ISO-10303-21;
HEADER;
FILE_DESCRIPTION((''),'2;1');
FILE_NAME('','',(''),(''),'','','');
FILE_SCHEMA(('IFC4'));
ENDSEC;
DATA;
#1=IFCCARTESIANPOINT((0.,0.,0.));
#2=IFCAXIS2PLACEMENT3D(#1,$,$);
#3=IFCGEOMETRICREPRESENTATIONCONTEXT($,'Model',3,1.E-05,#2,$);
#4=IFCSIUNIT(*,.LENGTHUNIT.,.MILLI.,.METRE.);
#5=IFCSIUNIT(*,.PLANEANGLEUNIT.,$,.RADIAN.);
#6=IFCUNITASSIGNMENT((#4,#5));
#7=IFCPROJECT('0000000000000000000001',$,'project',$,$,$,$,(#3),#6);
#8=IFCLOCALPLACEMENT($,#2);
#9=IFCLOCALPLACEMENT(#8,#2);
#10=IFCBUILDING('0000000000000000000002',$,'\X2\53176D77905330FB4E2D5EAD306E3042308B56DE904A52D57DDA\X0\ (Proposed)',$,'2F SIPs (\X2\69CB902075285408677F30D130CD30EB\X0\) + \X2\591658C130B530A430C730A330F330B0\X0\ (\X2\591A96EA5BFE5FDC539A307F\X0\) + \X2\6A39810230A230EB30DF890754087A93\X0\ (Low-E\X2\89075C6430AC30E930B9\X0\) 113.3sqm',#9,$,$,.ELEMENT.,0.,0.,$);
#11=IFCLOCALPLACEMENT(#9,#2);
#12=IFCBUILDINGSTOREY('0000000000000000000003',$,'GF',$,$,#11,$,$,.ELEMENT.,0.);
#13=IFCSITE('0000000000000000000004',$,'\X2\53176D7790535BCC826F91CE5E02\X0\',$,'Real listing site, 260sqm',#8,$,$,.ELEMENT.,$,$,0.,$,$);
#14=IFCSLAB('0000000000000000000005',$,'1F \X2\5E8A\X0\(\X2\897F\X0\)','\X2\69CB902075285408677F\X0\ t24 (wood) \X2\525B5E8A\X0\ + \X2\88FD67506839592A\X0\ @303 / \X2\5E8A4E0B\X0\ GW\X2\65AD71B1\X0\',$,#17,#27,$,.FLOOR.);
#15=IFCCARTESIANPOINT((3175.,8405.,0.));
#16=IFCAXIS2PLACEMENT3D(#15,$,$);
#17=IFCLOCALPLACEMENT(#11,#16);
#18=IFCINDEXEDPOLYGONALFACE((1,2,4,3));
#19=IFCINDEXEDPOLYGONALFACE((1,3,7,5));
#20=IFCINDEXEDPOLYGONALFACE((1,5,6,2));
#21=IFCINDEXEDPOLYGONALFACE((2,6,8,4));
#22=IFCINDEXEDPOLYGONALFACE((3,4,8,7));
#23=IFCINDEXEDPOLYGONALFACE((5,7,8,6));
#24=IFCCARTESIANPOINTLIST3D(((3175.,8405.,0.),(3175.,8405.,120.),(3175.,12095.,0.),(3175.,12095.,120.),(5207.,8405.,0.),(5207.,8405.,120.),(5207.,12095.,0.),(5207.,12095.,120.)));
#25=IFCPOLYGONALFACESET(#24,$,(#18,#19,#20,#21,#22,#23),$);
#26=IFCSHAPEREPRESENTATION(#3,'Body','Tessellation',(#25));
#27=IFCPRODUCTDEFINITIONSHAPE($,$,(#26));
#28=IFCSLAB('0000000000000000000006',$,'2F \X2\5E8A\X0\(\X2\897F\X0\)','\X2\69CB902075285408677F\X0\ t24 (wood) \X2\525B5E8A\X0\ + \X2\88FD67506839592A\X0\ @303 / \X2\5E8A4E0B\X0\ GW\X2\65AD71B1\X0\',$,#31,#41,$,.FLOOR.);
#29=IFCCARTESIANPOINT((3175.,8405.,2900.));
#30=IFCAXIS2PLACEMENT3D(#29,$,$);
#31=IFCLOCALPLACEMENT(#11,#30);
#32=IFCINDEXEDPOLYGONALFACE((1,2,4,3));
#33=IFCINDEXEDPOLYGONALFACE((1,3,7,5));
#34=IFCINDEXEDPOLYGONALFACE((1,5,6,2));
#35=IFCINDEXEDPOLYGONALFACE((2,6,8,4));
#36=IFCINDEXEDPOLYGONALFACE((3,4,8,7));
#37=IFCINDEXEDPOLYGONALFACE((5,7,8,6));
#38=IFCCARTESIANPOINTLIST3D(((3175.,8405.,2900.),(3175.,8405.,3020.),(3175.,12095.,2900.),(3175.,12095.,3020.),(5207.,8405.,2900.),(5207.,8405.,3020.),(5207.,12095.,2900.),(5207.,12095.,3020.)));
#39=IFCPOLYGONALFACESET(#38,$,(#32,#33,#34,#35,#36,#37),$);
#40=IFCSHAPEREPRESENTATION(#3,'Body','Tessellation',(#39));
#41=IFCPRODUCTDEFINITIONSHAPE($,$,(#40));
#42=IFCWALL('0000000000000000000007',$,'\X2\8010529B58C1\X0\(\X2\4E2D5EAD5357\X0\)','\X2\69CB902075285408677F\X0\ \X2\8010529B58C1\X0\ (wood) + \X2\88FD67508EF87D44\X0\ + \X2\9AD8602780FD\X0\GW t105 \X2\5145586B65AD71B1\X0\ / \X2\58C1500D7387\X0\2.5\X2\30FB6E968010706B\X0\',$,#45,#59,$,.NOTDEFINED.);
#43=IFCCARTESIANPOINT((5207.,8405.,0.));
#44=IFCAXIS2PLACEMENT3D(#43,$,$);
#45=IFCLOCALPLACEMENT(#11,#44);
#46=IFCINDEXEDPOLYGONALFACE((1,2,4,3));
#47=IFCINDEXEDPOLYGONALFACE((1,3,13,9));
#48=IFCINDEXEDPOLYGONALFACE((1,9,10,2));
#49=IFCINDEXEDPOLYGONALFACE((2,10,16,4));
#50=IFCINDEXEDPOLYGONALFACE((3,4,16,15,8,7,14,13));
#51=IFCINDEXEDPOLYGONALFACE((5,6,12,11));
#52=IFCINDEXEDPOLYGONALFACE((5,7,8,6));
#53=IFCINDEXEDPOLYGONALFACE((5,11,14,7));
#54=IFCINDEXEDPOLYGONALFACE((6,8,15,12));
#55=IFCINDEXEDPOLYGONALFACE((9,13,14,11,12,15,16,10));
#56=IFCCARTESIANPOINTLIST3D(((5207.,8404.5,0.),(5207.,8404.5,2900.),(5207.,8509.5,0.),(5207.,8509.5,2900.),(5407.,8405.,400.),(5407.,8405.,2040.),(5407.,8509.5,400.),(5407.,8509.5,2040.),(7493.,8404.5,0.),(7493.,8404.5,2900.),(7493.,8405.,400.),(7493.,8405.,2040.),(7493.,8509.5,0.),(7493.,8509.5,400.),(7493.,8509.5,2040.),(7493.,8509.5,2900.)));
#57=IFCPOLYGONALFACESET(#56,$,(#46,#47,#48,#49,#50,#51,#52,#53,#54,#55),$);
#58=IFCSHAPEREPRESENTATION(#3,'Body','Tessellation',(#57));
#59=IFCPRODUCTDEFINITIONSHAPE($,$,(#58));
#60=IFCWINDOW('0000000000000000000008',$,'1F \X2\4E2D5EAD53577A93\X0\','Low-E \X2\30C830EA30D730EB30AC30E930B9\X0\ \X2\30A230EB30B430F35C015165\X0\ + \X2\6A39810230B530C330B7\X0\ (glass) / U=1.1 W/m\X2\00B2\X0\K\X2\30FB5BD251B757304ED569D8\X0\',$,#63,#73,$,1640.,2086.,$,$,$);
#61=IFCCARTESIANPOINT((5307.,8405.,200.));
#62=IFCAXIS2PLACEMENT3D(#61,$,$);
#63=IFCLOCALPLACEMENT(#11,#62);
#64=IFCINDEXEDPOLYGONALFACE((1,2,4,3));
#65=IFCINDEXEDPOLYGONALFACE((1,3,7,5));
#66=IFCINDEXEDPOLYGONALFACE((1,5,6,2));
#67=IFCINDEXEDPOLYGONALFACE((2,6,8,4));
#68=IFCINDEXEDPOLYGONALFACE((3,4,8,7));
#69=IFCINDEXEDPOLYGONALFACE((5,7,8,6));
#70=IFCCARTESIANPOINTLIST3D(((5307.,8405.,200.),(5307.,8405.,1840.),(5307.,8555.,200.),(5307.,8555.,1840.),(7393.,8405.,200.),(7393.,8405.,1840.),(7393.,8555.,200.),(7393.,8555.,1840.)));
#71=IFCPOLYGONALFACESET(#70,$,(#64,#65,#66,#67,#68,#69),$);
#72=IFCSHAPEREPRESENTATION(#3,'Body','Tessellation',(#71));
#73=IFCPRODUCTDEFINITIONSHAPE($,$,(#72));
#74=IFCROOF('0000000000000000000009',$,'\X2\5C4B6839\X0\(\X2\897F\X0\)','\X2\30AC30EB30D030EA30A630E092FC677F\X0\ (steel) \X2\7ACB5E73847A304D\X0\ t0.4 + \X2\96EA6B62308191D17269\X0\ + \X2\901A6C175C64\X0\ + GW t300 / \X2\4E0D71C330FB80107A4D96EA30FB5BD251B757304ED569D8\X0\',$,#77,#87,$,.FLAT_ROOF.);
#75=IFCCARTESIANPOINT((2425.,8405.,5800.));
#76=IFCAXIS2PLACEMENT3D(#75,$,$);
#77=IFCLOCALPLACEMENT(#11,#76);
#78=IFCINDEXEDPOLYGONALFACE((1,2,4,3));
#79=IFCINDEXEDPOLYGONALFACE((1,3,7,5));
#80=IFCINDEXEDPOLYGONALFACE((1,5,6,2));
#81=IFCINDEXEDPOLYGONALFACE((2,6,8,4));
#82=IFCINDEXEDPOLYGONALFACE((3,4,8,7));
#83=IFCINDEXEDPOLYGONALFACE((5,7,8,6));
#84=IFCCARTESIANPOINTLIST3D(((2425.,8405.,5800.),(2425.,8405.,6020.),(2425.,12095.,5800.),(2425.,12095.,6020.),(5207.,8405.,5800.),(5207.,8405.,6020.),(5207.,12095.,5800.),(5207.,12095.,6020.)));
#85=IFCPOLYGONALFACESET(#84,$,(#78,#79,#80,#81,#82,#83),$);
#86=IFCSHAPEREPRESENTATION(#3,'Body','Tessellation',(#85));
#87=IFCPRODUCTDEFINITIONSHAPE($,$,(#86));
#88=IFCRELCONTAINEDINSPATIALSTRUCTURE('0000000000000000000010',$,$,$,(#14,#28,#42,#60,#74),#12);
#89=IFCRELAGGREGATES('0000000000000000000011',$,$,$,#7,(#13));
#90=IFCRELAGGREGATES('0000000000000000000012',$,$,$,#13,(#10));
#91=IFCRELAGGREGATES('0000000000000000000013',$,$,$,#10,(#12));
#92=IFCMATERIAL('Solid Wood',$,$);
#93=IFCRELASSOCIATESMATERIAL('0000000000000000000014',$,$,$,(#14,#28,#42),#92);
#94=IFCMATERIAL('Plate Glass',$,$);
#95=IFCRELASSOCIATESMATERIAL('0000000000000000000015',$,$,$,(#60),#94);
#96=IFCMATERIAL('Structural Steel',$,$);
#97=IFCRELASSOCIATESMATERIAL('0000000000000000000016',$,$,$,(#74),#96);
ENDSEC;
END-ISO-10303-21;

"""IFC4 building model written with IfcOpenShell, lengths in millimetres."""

from ifc_helpers import new_model, si_unit, frame, frame_2d, origin, place, context, project, spatial, rectangle, extrude, material, element, fill, save


model = new_model("IFC4")

# Units and contexts
model_context = context("Model", 3, precision=1e-05, world=origin())
ifc_project = project(units=[si_unit("LENGTHUNIT", "METRE", prefix="MILLI"), si_unit("PLANEANGLEUNIT", "RADIAN")], contexts=[model_context])

# Site, building, storey
site_placement = place(None, origin())
site = spatial("IfcSite", under=ifc_project, at=site_placement, Name="北海道富良野市", ObjectType="Real listing site, 260sqm", CompositionType="ELEMENT", RefElevation=0.0)
building_placement = place(site_placement, origin())
building = spatial("IfcBuilding", under=site, at=building_placement, Name="北海道・中庭のある回遊動線 (Proposed)", ObjectType="2F SIPs (構造用合板パネル) + 外壁サイディング (多雪対応厚み) + 樹脂アルミ複合窓 (Low-E複層ガラス) 113.3sqm", CompositionType="ELEMENT", ElevationOfRefHeight=0.0, ElevationOfTerrain=0.0)
storey_placement = place(building_placement, origin())
storey = spatial("IfcBuildingStorey", under=building, at=storey_placement, Name="GF", CompositionType="ELEMENT", Elevation=0.0)

# Shared definitions
ifc_material_1 = material(Name="Solid Wood")

# Slabs
slab_1_placement = place(storey_placement, frame((3175.0, 8405.0, 0.0)))
element("IfcSlab", 1, at=slab_1_placement, inside=storey, material=ifc_material_1, Name="1F 床(西)", Description="構造用合板 t24 (wood) 剛床 + 製材根太 @303 / 床下 GW断熱", PredefinedType="FLOOR", context=model_context, shape_type="SweptSolid", body=[
    extrude(rectangle(XDim=2032.0, YDim=3690.0, at=frame_2d((1016.0, 1845.0))), frame((3175.0, 8405.0, 0.0)), (0.0, 0.0, 1.0), 120.0),
])
slab_2_placement = place(storey_placement, frame((3175.0, 8405.0, 2900.0)))
element("IfcSlab", 2, at=slab_2_placement, inside=storey, material=ifc_material_1, Name="2F 床(西)", Description="構造用合板 t24 (wood) 剛床 + 製材根太 @303 / 床下 GW断熱", PredefinedType="FLOOR", context=model_context, shape_type="SweptSolid", body=[
    extrude(rectangle(XDim=2032.0, YDim=3690.0, at=frame_2d((1016.0, 1845.0))), frame((3175.0, 8405.0, 2900.0)), (0.0, 0.0, 1.0), 120.0),
])

# Wall, opening, window
wall_1_placement = place(storey_placement, frame((5207.0, 8405.0, 0.0)))
wall_1 = element("IfcWall", 3, at=wall_1_placement, inside=storey, material=ifc_material_1, Name="耐力壁(中庭南)", Description="構造用合板 耐力壁 (wood) + 製材軸組 + 高性能GW t105 充填断熱 / 壁倍率2.5・準耐火", PredefinedType="NOTDEFINED", context=model_context, shape_type="SweptSolid", body=[
    extrude(rectangle(XDim=2286.0, YDim=105.0, at=frame_2d((1143.0, 52.0))), frame((5207.0, 8405.0, 0.0)), (0.0, 0.0, 1.0), 2900.0),
])
opening_placement = place(storey_placement, frame((5307.0, 8405.0, 200.0)))
opening = element("IfcOpeningElement", 4, at=opening_placement, cuts=wall_1, PredefinedType="NOTDEFINED", context=model_context, shape_type="SweptSolid", body=[
    extrude(rectangle(XDim=2086.0, YDim=150.0, at=frame_2d((1043.0, 75.0))), frame((5307.0, 8405.0, 200.0)), (0.0, 0.0, 1.0), 1640.0),
])
ifc_material_2 = material(Name="Plate Glass")
window_placement = place(storey_placement, frame((5307.0, 8405.0, 200.0)))
window = element("IfcWindow", 5, at=window_placement, inside=storey, material=ifc_material_2, Name="1F 中庭南窓", Description="Low-E トリプルガラス アルゴン封入 + 樹脂サッシ (glass) / U=1.1 W/m²K・寒冷地仕様", OverallHeight=1640.0, OverallWidth=2086.0, context=model_context, shape_type="SweptSolid", body=[
    extrude(rectangle(XDim=2086.0, YDim=150.0, at=frame_2d((1043.0, 75.0))), frame((5307.0, 8405.0, 200.0)), (0.0, 0.0, 1.0), 1640.0),
])
fill(opening, window)

# Roof
ifc_material_3 = material(Name="Structural Steel")
for number, where, name in (
    (6, (2425.0, 8405.0, 5800.0), "屋根(西)"),
):
    element("IfcRoof", number, at=place(storey_placement, frame(where)), inside=storey, material=ifc_material_3, Name=name, Description="ガルバリウム鋼板 (steel) 立平葺き t0.4 + 雪止め金物 + 通気層 + GW t300 / 不燃・耐積雪・寒冷地仕様", PredefinedType="FLAT_ROOF", context=model_context, shape_type="SweptSolid", body=[
        extrude(rectangle(XDim=2782.0, YDim=3690.0, at=frame_2d((1391.0, 1845.0))), frame((2425.0, 8405.0, 5800.0)), (0.0, 0.0, 1.0), 220.0),
    ])

save(model, "model.ifc")
